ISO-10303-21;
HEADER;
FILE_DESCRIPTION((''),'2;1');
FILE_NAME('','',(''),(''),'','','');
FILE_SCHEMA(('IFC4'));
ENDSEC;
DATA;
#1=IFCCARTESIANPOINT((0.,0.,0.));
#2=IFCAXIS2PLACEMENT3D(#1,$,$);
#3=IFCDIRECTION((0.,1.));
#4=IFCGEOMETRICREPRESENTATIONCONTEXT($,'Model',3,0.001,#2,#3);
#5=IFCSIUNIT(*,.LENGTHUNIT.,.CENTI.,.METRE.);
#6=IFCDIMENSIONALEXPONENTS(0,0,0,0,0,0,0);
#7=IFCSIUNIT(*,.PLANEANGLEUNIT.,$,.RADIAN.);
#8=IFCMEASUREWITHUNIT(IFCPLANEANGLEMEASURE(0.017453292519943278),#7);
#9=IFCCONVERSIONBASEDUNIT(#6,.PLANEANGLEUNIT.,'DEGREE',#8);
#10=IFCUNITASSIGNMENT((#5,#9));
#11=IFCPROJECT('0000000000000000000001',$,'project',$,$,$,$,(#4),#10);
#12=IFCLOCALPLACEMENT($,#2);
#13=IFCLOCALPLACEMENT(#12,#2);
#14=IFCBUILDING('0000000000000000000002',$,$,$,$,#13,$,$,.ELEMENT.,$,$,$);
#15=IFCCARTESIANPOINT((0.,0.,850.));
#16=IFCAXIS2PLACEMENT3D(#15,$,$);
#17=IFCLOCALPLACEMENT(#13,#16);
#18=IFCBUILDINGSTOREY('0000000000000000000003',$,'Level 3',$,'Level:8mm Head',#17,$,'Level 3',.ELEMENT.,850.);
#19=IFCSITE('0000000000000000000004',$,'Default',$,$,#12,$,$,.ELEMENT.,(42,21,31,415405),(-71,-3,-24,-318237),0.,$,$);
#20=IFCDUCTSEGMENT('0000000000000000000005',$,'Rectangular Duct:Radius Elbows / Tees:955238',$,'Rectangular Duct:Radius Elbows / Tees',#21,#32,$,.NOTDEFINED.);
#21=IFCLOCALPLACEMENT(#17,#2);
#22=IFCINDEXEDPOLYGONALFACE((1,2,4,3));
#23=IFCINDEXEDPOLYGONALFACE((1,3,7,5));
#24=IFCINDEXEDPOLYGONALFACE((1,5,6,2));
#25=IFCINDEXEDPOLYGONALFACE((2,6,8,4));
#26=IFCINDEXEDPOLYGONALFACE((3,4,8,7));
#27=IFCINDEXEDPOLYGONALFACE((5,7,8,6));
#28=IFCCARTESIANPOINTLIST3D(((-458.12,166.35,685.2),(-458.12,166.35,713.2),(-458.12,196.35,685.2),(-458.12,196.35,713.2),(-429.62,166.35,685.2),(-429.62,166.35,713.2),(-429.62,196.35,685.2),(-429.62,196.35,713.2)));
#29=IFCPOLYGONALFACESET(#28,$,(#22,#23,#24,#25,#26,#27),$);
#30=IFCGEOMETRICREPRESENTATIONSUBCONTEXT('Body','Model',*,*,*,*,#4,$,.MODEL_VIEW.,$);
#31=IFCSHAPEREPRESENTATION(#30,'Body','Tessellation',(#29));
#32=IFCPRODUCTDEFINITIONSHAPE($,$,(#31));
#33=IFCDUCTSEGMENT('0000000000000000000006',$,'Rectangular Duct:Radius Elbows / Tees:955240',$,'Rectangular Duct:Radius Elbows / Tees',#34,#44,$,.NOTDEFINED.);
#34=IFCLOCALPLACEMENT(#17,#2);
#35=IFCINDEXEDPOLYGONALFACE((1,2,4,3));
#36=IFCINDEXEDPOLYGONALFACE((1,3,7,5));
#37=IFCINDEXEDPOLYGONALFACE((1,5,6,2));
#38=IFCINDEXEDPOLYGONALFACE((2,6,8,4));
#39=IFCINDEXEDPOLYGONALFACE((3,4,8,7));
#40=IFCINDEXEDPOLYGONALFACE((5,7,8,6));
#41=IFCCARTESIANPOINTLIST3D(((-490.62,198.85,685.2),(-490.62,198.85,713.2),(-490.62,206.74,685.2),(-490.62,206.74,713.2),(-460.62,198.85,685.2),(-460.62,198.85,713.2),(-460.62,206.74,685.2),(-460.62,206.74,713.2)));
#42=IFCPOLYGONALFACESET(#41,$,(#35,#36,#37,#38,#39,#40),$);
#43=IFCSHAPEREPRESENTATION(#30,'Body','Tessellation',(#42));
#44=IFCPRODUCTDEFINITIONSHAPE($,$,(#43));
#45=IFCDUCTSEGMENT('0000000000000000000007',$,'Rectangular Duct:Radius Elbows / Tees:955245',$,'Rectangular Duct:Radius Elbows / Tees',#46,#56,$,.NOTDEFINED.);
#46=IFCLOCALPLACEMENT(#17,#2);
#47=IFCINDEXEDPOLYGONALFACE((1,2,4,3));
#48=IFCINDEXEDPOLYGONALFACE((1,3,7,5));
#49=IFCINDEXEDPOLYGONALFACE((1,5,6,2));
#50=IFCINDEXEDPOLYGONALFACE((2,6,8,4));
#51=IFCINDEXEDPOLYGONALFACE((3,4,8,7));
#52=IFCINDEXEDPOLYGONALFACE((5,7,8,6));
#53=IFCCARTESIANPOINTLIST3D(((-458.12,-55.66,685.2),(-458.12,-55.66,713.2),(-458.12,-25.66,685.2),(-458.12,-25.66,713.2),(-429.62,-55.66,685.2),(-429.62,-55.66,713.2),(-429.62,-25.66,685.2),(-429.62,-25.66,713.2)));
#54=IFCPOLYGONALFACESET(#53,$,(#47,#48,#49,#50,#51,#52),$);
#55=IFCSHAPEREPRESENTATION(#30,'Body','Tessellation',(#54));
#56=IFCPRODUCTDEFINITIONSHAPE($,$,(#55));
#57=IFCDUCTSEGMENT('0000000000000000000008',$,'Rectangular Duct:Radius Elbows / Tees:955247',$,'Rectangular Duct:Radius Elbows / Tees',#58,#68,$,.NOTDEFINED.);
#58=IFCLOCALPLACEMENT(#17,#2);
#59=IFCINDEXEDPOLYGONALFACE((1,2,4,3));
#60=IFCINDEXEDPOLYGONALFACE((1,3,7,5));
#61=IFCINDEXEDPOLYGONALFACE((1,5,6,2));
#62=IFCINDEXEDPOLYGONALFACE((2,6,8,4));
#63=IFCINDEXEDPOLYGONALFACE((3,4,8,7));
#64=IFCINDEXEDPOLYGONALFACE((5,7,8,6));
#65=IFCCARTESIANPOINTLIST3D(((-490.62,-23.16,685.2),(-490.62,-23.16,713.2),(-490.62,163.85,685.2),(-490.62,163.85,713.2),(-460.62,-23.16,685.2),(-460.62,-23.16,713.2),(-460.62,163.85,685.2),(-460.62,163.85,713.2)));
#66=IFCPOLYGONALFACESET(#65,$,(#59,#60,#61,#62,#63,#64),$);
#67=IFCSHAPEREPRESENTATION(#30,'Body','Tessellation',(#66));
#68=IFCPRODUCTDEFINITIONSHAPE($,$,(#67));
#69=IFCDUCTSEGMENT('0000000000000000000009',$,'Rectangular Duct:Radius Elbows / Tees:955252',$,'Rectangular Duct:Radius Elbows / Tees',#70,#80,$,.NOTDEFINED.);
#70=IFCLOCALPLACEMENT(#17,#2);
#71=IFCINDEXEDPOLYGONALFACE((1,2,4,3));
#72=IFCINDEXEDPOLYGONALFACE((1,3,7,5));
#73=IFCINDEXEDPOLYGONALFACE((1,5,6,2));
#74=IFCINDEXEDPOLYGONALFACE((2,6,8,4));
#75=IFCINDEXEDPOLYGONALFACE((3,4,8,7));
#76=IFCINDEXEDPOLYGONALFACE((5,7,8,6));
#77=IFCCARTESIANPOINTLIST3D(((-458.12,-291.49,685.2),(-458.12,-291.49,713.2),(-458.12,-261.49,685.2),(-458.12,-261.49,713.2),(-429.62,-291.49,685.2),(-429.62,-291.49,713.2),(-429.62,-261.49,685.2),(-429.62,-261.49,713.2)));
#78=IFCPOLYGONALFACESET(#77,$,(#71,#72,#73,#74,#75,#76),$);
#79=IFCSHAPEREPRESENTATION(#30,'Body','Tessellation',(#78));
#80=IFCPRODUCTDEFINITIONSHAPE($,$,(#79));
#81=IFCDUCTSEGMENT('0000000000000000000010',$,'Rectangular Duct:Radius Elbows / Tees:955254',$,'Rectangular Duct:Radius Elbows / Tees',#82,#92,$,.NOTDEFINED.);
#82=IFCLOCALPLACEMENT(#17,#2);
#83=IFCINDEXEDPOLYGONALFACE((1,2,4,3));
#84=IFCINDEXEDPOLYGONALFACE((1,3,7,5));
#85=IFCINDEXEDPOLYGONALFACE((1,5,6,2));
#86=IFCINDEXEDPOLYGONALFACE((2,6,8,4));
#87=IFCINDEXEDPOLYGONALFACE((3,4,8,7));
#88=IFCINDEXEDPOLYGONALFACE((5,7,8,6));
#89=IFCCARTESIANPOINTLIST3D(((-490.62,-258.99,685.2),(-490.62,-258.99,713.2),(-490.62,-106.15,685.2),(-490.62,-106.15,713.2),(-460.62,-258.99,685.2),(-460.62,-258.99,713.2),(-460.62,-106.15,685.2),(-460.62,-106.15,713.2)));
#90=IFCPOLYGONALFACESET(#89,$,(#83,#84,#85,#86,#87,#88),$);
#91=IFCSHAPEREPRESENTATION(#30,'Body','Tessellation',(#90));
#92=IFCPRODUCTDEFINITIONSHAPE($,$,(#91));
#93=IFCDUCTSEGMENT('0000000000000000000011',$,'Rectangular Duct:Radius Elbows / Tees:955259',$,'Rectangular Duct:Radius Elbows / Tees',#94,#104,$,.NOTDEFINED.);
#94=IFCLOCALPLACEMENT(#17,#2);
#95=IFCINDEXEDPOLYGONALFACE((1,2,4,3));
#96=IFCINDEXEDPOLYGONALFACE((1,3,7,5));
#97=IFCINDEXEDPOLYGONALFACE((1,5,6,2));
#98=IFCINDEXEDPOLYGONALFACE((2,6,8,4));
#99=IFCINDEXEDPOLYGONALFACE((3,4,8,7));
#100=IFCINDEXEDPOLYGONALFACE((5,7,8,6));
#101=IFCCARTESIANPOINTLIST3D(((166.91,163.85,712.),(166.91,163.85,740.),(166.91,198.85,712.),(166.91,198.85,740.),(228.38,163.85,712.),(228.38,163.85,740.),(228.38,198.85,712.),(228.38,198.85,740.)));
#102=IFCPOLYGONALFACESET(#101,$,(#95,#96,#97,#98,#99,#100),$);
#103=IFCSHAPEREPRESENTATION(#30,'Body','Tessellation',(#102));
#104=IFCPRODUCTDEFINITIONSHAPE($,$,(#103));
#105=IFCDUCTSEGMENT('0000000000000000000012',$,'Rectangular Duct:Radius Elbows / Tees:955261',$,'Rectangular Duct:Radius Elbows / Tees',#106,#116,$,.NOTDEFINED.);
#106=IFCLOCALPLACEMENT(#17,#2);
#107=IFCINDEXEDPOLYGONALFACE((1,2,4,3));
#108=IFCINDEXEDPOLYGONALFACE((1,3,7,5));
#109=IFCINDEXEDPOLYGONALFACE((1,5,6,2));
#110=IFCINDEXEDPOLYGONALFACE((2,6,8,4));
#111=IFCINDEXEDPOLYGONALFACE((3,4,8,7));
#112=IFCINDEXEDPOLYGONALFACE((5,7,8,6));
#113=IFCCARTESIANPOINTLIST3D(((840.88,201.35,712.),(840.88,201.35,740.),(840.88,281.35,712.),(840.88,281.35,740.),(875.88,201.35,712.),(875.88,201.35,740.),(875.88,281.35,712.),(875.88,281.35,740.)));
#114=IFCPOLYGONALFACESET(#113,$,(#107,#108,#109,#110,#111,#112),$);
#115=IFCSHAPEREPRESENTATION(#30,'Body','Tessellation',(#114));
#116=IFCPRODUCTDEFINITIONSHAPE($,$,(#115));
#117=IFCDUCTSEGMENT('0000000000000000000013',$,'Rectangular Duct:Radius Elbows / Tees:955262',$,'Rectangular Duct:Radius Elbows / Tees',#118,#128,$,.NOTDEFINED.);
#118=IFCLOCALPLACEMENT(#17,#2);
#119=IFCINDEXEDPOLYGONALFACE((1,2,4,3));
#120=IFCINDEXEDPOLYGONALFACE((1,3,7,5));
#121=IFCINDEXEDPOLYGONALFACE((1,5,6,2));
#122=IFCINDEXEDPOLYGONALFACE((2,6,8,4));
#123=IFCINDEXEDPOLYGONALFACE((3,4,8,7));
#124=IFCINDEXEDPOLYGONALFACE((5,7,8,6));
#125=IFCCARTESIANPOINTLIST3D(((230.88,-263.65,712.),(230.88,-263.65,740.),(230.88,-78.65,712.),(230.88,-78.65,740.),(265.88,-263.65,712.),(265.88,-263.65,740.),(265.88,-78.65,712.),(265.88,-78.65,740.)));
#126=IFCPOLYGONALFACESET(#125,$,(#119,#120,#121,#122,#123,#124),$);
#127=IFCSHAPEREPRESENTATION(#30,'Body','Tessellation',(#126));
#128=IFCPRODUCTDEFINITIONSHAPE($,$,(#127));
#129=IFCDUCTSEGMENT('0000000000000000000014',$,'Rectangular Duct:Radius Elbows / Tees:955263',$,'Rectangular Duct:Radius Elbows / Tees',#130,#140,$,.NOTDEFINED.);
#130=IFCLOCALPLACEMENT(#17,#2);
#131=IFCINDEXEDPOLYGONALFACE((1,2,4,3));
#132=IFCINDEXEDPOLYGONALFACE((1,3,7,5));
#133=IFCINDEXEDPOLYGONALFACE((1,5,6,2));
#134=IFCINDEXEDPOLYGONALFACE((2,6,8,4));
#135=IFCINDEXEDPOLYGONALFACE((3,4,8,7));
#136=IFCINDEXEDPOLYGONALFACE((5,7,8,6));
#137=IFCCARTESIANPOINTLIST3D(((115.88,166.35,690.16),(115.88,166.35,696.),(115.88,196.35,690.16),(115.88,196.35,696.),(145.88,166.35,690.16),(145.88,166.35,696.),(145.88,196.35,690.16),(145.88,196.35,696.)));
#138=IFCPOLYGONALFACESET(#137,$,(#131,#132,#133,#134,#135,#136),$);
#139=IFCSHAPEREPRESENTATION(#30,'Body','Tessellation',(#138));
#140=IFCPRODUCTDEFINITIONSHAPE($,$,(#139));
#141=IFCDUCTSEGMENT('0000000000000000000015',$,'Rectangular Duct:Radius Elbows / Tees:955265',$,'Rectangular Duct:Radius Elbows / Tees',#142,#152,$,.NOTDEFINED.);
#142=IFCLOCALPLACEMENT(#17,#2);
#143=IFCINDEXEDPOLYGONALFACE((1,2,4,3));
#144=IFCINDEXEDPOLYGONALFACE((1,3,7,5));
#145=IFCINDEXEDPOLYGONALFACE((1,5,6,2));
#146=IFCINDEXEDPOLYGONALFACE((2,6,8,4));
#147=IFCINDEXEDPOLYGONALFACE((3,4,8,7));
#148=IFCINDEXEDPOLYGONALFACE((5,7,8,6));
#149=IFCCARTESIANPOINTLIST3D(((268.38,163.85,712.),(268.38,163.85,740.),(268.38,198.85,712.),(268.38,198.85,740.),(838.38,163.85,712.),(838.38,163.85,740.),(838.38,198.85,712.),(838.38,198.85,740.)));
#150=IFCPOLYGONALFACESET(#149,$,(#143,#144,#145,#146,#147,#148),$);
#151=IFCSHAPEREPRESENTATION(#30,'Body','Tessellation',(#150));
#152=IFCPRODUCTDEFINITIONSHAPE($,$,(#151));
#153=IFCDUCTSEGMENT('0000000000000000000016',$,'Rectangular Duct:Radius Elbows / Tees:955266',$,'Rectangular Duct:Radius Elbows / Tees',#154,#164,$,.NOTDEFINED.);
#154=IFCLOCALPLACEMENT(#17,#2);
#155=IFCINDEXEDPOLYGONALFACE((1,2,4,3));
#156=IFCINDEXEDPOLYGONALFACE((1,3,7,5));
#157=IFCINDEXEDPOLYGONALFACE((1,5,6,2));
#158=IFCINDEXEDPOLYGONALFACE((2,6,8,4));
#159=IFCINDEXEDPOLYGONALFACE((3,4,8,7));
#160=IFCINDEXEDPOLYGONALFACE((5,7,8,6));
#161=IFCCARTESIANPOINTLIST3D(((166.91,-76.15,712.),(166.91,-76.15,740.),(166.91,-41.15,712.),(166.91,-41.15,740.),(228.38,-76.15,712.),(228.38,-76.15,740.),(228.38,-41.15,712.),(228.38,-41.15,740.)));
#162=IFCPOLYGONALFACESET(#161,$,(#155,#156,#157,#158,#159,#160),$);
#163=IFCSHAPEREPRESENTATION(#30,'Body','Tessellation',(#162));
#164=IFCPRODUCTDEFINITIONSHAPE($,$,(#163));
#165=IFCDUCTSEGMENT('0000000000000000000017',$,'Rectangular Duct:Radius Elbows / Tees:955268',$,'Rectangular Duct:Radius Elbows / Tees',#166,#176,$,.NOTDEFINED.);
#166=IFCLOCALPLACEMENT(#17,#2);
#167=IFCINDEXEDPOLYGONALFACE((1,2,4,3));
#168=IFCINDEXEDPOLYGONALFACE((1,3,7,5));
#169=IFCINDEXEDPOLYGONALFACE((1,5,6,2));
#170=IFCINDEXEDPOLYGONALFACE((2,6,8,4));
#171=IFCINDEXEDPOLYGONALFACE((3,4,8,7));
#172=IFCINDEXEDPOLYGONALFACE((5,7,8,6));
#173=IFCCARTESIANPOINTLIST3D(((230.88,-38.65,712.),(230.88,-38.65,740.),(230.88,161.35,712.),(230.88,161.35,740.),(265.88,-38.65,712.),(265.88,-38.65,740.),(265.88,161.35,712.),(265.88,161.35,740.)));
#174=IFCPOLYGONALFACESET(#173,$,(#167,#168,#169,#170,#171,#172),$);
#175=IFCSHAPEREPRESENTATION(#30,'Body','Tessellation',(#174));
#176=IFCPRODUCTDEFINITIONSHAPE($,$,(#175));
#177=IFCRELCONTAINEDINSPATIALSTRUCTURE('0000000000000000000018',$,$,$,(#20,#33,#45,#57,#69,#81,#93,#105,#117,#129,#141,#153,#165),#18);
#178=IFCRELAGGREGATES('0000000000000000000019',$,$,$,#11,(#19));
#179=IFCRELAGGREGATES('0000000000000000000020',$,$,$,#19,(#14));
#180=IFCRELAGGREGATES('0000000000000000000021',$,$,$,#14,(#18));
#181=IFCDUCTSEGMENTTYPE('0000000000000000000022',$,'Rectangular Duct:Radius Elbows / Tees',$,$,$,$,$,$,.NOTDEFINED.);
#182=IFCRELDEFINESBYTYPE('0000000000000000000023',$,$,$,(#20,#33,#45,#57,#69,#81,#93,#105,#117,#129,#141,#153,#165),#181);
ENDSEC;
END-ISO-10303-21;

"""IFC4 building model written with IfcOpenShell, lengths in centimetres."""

from ifc_helpers import new_model, entity, si_unit, converted_unit, direction, frame, origin, place, context, subcontext, project, spatial, indexed_curve, outline, extrude, type_object, element, save


model = new_model("IFC4")

# Units and contexts
model_context = context("Model", 3, precision=0.001, world=origin(), true_north=direction((0.0, 1.0)))
body_context = subcontext(model_context, "Body", "Model", "MODEL_VIEW")
ifc_project = project(units=[si_unit("LENGTHUNIT", "METRE", prefix="CENTI"), converted_unit("PLANEANGLEUNIT", "DEGREE", entity("IfcPlaneAngleMeasure", 0.017453292519943278), si_unit("PLANEANGLEUNIT", "RADIAN"), dimensions=[0, 0, 0, 0, 0, 0, 0])], contexts=[model_context])

# Site, building, storey
site_placement = place(None, origin())
site = spatial("IfcSite", under=ifc_project, at=site_placement, Name="Default", CompositionType="ELEMENT", RefLatitude=(42, 21, 31, 415405), RefLongitude=(-71, -3, -24, -318237), RefElevation=0.0)
building_placement = place(site_placement, origin())
building = spatial("IfcBuilding", under=site, at=building_placement, CompositionType="ELEMENT")
storey_placement = place(building_placement, frame((0.0, 0.0, 850.0)))
storey = spatial("IfcBuildingStorey", under=building, at=storey_placement, Name="Level 3", ObjectType="Level:8mm Head", LongName="Level 3", CompositionType="ELEMENT", Elevation=850.0)

# Duct segments
duct_segment_type_1 = type_object("IfcDuctSegmentType", Name="Rectangular Duct:Radius Elbows / Tees", PredefinedType="NOTDEFINED")
duct_segment_1_placement = place(storey_placement, origin())
element("IfcDuctSegment", 1, at=duct_segment_1_placement, inside=storey, type_object=duct_segment_type_1, Name="Rectangular Duct:Radius Elbows / Tees:955238", ObjectType="Rectangular Duct:Radius Elbows / Tees", PredefinedType="NOTDEFINED", context=body_context, shape_type="SweptSolid", body=[
    extrude(outline(indexed_curve([(-14.25, -15.0), (14.25, -15.0), (14.25, 15.0), (-14.25, 15.0), (-14.25, -15.0)], self_intersect=False)), frame((-443.87, 181.35, 685.2)), (0.0, 0.0, 1.0), 28.0),
])
duct_segment_2_placement = place(storey_placement, origin())
element("IfcDuctSegment", 2, at=duct_segment_2_placement, inside=storey, type_object=duct_segment_type_1, Name="Rectangular Duct:Radius Elbows / Tees:955240", ObjectType="Rectangular Duct:Radius Elbows / Tees", PredefinedType="NOTDEFINED", context=body_context, shape_type="SweptSolid", body=[
    extrude(outline(indexed_curve([(-3.95, -15.0), (3.95, -15.0), (3.95, 15.0), (-3.95, 15.0), (-3.95, -15.0)], self_intersect=False)), frame((-475.62, 202.79, 685.2), z_axis=(0.0, 0.0, 1.0), x_axis=(0.0, -1.0, 0.0)), (0.0, 0.0, 1.0), 28.0),
])
duct_segment_3_placement = place(storey_placement, origin())
element("IfcDuctSegment", 3, at=duct_segment_3_placement, inside=storey, type_object=duct_segment_type_1, Name="Rectangular Duct:Radius Elbows / Tees:955245", ObjectType="Rectangular Duct:Radius Elbows / Tees", PredefinedType="NOTDEFINED", context=body_context, shape_type="SweptSolid", body=[
    extrude(outline(indexed_curve([(-14.25, -15.0), (14.25, -15.0), (14.25, 15.0), (-14.25, 15.0), (-14.25, -15.0)], self_intersect=False)), frame((-443.87, -40.66, 685.2)), (0.0, 0.0, 1.0), 28.0),
])
duct_segment_4_placement = place(storey_placement, origin())
element("IfcDuctSegment", 4, at=duct_segment_4_placement, inside=storey, type_object=duct_segment_type_1, Name="Rectangular Duct:Radius Elbows / Tees:955247", ObjectType="Rectangular Duct:Radius Elbows / Tees", PredefinedType="NOTDEFINED", context=body_context, shape_type="SweptSolid", body=[
    extrude(outline(indexed_curve([(-93.5, -15.0), (93.5, -15.0), (93.5, 15.0), (-93.5, 15.0), (-93.5, -15.0)], self_intersect=False)), frame((-475.62, 70.34, 685.2), z_axis=(0.0, 0.0, 1.0), x_axis=(0.0, -1.0, 0.0)), (0.0, 0.0, 1.0), 28.0),
])
duct_segment_5_placement = place(storey_placement, origin())
element("IfcDuctSegment", 5, at=duct_segment_5_placement, inside=storey, type_object=duct_segment_type_1, Name="Rectangular Duct:Radius Elbows / Tees:955252", ObjectType="Rectangular Duct:Radius Elbows / Tees", PredefinedType="NOTDEFINED", context=body_context, shape_type="SweptSolid", body=[
    extrude(outline(indexed_curve([(-14.25, -15.0), (14.25, -15.0), (14.25, 15.0), (-14.25, 15.0), (-14.25, -15.0)], self_intersect=False)), frame((-443.87, -276.49, 685.2)), (0.0, 0.0, 1.0), 28.0),
])
duct_segment_6_placement = place(storey_placement, origin())
element("IfcDuctSegment", 6, at=duct_segment_6_placement, inside=storey, type_object=duct_segment_type_1, Name="Rectangular Duct:Radius Elbows / Tees:955254", ObjectType="Rectangular Duct:Radius Elbows / Tees", PredefinedType="NOTDEFINED", context=body_context, shape_type="SweptSolid", body=[
    extrude(outline(indexed_curve([(-76.42, -15.0), (76.42, -15.0), (76.42, 15.0), (-76.42, 15.0), (-76.42, -15.0)], self_intersect=False)), frame((-475.62, -182.57, 685.2), z_axis=(0.0, 0.0, 1.0), x_axis=(0.0, -1.0, 0.0)), (0.0, 0.0, 1.0), 28.0),
])
duct_segment_7_placement = place(storey_placement, origin())
element("IfcDuctSegment", 7, at=duct_segment_7_placement, inside=storey, type_object=duct_segment_type_1, Name="Rectangular Duct:Radius Elbows / Tees:955259", ObjectType="Rectangular Duct:Radius Elbows / Tees", PredefinedType="NOTDEFINED", context=body_context, shape_type="SweptSolid", body=[
    extrude(outline(indexed_curve([(-30.73, -17.5), (30.73, -17.5), (30.73, 17.5), (-30.73, 17.5), (-30.73, -17.5)], self_intersect=False)), frame((197.64, 181.35, 712.0), z_axis=(0.0, 0.0, 1.0), x_axis=(-1.0, 0.0, 0.0)), (0.0, 0.0, 1.0), 28.0),
])
duct_segment_8_placement = place(storey_placement, origin())
element("IfcDuctSegment", 8, at=duct_segment_8_placement, inside=storey, type_object=duct_segment_type_1, Name="Rectangular Duct:Radius Elbows / Tees:955261", ObjectType="Rectangular Duct:Radius Elbows / Tees", PredefinedType="NOTDEFINED", context=body_context, shape_type="SweptSolid", body=[
    extrude(outline(indexed_curve([(-40.0, -17.5), (40.0, -17.5), (40.0, 17.5), (-40.0, 17.5), (-40.0, -17.5)], self_intersect=False)), frame((858.38, 241.35, 712.0), z_axis=(0.0, 0.0, 1.0), x_axis=(0.0, -1.0, 0.0)), (0.0, 0.0, 1.0), 28.0),
])
duct_segment_9_placement = place(storey_placement, origin())
element("IfcDuctSegment", 9, at=duct_segment_9_placement, inside=storey, type_object=duct_segment_type_1, Name="Rectangular Duct:Radius Elbows / Tees:955262", ObjectType="Rectangular Duct:Radius Elbows / Tees", PredefinedType="NOTDEFINED", context=body_context, shape_type="SweptSolid", body=[
    extrude(outline(indexed_curve([(-92.5, -17.5), (92.5, -17.5), (92.5, 17.5), (-92.5, 17.5), (-92.5, -17.5)], self_intersect=False)), frame((248.38, -171.15, 712.0), z_axis=(0.0, 0.0, 1.0), x_axis=(0.0, -1.0, 0.0)), (0.0, 0.0, 1.0), 28.0),
])
duct_segment_10_placement = place(storey_placement, origin())
element("IfcDuctSegment", 10, at=duct_segment_10_placement, inside=storey, type_object=duct_segment_type_1, Name="Rectangular Duct:Radius Elbows / Tees:955263", ObjectType="Rectangular Duct:Radius Elbows / Tees", PredefinedType="NOTDEFINED", context=body_context, shape_type="SweptSolid", body=[
    extrude(outline(indexed_curve([(-15.0, -15.0), (15.0, -15.0), (15.0, 15.0), (-15.0, 15.0), (-15.0, -15.0)], self_intersect=False)), frame((130.88, 181.35, 690.16)), (0.0, 0.0, 1.0), 5.84),
])
duct_segment_11_placement = place(storey_placement, origin())
element("IfcDuctSegment", 11, at=duct_segment_11_placement, inside=storey, type_object=duct_segment_type_1, Name="Rectangular Duct:Radius Elbows / Tees:955265", ObjectType="Rectangular Duct:Radius Elbows / Tees", PredefinedType="NOTDEFINED", context=body_context, shape_type="SweptSolid", body=[
    extrude(outline(indexed_curve([(-285.0, -17.5), (285.0, -17.5), (285.0, 17.5), (-285.0, 17.5), (-285.0, -17.5)], self_intersect=False)), frame((553.38, 181.35, 712.0), z_axis=(0.0, 0.0, 1.0), x_axis=(-1.0, 0.0, 0.0)), (0.0, 0.0, 1.0), 28.0),
])
duct_segment_12_placement = place(storey_placement, origin())
element("IfcDuctSegment", 12, at=duct_segment_12_placement, inside=storey, type_object=duct_segment_type_1, Name="Rectangular Duct:Radius Elbows / Tees:955266", ObjectType="Rectangular Duct:Radius Elbows / Tees", PredefinedType="NOTDEFINED", context=body_context, shape_type="SweptSolid", body=[
    extrude(outline(indexed_curve([(-30.73, -17.5), (30.73, -17.5), (30.73, 17.5), (-30.73, 17.5), (-30.73, -17.5)], self_intersect=False)), frame((197.64, -58.65, 712.0)), (0.0, 0.0, 1.0), 28.0),
])
duct_segment_13_placement = place(storey_placement, origin())
element("IfcDuctSegment", 13, at=duct_segment_13_placement, inside=storey, type_object=duct_segment_type_1, Name="Rectangular Duct:Radius Elbows / Tees:955268", ObjectType="Rectangular Duct:Radius Elbows / Tees", PredefinedType="NOTDEFINED", context=body_context, shape_type="SweptSolid", body=[
    extrude(outline(indexed_curve([(-100.0, -17.5), (100.0, -17.5), (100.0, 17.5), (-100.0, 17.5), (-100.0, -17.5)], self_intersect=False)), frame((248.38, 61.35, 712.0), z_axis=(0.0, 0.0, 1.0), x_axis=(0.0, -1.0, 0.0)), (0.0, 0.0, 1.0), 28.0),
])

save(model, "model.ifc")
